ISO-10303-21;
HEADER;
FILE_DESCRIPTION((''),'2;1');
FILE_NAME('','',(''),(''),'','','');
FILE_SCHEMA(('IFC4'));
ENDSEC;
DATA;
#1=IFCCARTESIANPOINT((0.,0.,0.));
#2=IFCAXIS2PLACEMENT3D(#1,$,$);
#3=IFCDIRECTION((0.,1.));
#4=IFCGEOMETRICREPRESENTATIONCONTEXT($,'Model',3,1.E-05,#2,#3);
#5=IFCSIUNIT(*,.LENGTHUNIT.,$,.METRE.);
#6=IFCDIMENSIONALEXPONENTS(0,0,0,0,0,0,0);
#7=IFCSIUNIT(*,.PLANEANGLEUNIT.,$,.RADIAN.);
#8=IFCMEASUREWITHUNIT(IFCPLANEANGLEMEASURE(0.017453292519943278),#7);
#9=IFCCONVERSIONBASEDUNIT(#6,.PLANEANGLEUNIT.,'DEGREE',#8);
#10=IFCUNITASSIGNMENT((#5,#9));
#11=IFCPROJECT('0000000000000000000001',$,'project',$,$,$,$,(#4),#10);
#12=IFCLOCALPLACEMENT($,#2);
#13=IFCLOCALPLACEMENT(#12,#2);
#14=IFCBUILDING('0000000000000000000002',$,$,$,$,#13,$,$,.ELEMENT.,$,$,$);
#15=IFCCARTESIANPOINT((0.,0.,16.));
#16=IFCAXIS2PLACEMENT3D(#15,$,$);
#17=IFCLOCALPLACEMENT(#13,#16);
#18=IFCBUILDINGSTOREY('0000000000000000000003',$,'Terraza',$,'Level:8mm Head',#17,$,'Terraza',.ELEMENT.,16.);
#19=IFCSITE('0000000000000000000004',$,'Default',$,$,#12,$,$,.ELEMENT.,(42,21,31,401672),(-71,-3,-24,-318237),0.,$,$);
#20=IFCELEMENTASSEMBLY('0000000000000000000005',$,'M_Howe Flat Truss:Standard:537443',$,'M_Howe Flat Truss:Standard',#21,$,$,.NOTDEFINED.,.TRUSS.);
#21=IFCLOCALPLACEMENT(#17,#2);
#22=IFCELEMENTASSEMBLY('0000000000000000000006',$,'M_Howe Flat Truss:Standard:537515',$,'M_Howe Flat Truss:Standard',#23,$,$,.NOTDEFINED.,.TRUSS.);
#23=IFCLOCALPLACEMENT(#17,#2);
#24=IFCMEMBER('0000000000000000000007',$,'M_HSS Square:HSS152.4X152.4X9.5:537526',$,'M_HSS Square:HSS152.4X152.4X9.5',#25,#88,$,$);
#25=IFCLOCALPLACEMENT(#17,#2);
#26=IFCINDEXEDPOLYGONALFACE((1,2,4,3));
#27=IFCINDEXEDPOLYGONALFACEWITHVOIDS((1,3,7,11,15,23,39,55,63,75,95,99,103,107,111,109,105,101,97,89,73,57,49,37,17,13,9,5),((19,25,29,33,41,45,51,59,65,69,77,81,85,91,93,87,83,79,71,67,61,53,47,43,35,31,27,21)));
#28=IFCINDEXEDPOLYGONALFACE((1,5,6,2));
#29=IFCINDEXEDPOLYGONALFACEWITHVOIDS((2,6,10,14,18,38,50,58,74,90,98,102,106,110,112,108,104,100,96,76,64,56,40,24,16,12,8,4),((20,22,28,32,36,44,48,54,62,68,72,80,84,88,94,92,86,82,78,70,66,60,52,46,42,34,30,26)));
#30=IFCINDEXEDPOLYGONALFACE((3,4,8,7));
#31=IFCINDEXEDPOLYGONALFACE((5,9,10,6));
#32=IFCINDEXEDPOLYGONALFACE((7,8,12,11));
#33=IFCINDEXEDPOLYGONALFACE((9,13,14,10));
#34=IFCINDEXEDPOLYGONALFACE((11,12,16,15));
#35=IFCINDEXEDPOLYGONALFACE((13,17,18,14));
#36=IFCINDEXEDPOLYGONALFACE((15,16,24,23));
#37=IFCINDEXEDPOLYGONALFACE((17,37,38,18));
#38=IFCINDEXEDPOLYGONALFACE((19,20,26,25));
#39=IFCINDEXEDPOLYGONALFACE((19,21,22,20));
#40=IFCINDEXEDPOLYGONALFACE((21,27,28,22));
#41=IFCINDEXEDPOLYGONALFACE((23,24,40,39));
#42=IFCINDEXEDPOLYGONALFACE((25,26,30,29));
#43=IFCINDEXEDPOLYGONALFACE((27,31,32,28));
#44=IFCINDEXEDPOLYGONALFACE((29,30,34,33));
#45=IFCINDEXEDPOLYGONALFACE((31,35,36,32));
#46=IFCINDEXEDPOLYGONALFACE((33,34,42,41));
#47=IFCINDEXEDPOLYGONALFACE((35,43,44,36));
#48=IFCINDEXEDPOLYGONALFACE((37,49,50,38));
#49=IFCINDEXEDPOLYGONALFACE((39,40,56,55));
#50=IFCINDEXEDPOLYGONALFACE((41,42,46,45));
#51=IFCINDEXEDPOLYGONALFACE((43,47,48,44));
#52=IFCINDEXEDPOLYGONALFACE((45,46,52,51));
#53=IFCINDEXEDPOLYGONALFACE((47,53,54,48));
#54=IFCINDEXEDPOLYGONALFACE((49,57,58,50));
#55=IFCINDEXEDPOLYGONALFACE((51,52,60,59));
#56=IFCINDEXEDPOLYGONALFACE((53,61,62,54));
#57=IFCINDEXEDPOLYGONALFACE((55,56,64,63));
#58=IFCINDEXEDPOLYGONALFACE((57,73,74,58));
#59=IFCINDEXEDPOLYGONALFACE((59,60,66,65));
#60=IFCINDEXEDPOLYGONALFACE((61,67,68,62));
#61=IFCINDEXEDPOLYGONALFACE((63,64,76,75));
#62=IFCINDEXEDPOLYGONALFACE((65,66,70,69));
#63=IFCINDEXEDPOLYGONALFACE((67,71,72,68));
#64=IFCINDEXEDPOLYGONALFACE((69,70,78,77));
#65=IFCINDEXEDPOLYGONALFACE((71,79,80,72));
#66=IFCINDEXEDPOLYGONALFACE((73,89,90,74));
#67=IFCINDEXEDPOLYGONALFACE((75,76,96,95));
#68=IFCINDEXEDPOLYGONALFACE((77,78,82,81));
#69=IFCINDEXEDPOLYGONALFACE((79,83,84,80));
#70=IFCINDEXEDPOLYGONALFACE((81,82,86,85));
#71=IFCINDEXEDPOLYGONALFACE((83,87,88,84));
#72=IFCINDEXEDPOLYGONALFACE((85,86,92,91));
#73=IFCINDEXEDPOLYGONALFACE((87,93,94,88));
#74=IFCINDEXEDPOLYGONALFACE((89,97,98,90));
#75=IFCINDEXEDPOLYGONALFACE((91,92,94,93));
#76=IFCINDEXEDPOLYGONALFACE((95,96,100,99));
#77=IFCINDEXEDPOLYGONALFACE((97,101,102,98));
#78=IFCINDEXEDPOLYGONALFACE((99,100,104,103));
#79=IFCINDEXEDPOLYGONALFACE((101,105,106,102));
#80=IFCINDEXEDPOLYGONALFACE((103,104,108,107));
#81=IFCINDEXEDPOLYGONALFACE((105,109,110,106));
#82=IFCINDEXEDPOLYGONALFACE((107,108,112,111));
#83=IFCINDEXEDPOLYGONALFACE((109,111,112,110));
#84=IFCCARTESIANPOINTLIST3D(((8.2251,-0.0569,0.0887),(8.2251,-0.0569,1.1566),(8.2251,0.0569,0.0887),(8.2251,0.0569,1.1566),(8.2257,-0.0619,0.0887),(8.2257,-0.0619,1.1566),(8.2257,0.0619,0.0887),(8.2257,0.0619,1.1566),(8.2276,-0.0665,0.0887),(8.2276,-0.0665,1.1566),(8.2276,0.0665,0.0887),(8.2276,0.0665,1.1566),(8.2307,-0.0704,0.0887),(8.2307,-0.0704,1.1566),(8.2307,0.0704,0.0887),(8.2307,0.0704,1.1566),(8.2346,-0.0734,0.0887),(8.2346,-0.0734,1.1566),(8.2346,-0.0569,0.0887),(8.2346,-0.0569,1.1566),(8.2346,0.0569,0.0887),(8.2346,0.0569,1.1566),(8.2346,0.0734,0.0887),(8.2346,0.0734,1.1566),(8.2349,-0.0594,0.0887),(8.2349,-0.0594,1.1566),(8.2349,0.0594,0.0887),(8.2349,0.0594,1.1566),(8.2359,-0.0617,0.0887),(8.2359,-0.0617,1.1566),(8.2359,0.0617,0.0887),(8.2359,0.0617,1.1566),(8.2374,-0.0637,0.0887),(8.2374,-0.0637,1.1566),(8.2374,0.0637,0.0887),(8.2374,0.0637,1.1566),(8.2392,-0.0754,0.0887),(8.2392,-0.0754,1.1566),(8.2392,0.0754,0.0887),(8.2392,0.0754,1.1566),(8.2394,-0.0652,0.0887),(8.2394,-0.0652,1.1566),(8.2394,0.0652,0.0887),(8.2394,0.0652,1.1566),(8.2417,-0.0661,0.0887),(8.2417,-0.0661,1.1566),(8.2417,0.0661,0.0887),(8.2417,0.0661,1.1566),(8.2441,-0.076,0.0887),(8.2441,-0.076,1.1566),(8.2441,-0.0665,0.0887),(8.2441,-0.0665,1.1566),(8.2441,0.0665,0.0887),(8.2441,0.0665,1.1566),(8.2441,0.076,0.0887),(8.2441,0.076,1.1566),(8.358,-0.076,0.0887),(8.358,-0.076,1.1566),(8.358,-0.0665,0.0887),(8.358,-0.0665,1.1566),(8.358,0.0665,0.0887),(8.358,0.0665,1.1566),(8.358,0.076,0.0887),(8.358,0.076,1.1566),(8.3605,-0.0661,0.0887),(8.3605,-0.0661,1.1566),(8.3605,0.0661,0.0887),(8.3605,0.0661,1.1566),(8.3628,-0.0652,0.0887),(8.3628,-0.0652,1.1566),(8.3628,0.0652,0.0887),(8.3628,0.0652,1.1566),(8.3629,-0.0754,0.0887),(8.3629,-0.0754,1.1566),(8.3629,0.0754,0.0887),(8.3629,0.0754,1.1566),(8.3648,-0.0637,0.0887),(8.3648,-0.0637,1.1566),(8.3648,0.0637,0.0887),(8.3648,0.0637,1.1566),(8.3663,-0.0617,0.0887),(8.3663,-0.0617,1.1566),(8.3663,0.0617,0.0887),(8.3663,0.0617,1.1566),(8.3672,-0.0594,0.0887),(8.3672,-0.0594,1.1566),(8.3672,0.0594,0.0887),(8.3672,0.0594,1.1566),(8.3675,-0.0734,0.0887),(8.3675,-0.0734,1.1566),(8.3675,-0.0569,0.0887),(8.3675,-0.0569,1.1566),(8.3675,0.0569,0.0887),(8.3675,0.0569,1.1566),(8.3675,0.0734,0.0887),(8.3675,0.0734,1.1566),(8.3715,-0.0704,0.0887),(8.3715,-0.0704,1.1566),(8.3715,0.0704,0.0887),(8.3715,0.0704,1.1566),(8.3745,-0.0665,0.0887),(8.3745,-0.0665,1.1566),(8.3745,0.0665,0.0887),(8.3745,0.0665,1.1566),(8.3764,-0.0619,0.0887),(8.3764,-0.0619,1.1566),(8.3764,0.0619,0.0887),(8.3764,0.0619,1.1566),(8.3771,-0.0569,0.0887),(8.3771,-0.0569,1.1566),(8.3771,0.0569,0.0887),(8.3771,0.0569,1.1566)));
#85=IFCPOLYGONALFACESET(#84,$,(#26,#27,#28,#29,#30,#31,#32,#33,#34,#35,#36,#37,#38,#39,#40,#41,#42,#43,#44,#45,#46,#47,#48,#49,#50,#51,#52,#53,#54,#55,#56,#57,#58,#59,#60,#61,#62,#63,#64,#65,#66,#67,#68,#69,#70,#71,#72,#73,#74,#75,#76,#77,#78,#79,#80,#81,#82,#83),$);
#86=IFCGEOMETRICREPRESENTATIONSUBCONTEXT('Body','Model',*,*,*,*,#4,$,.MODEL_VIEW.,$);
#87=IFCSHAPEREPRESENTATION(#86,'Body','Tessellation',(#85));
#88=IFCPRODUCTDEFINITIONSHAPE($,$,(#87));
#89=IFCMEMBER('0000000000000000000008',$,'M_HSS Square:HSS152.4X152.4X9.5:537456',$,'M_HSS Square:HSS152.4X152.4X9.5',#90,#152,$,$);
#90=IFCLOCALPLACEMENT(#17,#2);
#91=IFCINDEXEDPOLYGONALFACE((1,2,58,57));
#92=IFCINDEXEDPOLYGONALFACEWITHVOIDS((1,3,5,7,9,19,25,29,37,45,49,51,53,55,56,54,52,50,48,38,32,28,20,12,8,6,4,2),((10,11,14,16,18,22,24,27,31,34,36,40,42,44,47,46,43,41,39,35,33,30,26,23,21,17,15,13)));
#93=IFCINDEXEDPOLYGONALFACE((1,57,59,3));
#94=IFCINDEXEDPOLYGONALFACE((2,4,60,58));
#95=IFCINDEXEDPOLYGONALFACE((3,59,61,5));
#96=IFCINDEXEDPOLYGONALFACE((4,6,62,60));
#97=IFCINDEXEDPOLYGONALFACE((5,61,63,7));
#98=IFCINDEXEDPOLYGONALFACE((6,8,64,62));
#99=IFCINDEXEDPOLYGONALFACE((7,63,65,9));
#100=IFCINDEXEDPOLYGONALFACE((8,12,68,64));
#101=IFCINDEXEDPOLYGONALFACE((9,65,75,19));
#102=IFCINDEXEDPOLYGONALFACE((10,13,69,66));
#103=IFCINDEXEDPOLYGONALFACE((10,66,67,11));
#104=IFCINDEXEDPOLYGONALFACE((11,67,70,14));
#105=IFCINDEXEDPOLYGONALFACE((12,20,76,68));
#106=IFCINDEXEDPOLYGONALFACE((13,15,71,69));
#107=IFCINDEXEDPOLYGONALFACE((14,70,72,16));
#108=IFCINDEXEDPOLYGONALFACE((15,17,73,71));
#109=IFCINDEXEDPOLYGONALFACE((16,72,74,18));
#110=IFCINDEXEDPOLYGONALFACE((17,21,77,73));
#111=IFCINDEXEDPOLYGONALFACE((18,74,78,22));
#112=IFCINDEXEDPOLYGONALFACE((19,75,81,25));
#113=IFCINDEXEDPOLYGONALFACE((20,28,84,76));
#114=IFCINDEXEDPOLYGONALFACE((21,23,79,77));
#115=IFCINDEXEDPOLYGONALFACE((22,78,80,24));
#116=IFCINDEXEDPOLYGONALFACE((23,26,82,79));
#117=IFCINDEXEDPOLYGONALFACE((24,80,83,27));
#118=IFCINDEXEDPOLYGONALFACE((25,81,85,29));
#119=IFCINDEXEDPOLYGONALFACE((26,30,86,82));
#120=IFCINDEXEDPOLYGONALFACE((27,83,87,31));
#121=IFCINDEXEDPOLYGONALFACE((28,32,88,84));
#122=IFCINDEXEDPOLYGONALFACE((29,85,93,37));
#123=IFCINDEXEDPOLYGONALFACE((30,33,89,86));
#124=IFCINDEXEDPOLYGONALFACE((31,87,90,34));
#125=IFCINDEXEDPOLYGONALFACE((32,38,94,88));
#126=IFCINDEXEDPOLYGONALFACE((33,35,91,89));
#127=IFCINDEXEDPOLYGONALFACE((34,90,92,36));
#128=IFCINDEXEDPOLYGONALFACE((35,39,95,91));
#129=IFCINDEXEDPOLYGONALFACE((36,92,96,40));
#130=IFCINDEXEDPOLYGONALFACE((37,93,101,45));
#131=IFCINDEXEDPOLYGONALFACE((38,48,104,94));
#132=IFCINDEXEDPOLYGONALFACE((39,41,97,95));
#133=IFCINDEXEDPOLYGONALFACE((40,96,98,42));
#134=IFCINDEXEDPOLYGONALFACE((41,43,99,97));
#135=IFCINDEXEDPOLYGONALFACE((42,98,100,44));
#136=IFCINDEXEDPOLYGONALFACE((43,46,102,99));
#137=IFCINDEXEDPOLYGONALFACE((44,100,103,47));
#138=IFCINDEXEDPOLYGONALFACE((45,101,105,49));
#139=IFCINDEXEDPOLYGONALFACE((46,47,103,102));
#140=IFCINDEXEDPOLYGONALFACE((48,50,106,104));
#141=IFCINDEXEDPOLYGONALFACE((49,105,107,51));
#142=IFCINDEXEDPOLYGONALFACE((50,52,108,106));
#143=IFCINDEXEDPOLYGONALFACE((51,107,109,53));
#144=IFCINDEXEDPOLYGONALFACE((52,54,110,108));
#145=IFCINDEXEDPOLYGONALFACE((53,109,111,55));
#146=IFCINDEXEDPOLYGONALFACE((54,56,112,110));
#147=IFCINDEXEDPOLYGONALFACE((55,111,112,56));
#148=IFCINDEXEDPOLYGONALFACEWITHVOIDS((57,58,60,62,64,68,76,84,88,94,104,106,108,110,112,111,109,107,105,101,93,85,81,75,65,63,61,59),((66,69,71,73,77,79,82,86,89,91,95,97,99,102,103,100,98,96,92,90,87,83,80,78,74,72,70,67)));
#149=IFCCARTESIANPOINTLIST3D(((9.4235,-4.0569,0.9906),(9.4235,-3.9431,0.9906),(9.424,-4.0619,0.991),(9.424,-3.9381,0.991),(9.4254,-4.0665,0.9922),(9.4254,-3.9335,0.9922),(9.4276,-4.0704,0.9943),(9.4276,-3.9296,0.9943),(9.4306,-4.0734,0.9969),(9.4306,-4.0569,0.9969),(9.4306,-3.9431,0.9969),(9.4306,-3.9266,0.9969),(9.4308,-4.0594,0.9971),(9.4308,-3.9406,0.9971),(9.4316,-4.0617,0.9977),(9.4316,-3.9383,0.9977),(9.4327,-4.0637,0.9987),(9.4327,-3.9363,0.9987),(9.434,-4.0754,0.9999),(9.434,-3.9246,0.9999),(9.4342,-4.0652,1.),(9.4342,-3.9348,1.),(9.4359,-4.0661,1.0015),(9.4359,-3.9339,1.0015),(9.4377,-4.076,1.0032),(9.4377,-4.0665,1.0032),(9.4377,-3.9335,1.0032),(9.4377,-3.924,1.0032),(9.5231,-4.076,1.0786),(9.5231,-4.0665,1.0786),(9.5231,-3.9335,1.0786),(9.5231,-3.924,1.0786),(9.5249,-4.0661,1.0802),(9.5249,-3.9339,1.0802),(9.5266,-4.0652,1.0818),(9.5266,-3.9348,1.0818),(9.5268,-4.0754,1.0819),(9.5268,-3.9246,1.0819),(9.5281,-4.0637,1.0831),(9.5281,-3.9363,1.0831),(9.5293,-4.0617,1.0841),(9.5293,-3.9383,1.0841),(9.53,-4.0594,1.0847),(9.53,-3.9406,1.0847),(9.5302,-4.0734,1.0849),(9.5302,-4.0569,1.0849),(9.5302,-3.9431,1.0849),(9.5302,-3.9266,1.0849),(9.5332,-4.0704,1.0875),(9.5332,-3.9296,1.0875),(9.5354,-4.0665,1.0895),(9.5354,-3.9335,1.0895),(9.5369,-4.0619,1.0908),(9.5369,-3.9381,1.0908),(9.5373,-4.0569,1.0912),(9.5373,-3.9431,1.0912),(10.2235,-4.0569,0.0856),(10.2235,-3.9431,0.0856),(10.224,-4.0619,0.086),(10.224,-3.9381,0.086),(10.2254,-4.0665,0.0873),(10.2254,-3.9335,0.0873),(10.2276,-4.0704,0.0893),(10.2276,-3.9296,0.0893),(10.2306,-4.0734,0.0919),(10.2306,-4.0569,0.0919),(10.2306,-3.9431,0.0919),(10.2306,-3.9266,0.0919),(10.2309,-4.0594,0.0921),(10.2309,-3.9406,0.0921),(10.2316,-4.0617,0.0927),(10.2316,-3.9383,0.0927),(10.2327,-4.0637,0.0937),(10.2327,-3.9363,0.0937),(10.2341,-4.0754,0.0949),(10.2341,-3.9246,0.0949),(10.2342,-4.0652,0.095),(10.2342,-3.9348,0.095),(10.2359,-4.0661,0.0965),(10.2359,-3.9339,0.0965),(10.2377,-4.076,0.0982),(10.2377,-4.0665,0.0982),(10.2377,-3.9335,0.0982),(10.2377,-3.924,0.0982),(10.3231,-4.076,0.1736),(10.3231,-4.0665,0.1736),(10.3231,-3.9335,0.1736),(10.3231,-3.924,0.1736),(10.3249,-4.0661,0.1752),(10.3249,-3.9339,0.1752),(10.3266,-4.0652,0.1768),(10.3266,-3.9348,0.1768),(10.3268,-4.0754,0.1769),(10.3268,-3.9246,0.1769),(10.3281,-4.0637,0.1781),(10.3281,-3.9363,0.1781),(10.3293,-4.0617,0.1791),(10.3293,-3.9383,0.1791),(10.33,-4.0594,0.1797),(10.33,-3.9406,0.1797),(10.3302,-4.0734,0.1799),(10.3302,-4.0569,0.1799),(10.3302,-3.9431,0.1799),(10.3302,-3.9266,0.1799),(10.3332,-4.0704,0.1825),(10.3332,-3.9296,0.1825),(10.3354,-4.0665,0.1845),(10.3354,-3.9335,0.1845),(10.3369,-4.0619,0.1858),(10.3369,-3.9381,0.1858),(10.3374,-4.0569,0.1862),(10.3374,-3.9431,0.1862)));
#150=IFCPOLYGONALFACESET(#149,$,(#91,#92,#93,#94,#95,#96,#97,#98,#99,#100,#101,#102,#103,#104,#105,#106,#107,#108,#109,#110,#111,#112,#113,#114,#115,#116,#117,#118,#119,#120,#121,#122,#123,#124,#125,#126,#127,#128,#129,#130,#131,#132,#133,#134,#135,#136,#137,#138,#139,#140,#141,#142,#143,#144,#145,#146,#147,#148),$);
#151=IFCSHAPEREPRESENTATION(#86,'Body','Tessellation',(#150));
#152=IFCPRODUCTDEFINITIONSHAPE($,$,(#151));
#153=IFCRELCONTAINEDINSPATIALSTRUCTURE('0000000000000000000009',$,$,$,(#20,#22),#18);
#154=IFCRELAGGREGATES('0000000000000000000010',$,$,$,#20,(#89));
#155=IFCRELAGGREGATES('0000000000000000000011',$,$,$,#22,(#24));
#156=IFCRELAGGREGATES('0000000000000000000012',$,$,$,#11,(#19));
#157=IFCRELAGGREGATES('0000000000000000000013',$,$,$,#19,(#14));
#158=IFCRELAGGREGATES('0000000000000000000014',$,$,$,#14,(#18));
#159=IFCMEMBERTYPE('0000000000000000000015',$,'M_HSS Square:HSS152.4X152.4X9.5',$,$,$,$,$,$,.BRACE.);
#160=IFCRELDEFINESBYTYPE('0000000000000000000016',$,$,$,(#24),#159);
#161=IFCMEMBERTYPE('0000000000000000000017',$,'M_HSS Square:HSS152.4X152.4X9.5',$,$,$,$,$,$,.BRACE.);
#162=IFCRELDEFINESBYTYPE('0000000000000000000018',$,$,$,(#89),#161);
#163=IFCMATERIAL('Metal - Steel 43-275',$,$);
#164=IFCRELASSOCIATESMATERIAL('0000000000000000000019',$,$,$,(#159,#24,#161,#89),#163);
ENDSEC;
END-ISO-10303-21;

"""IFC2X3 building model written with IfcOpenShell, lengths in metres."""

from ifc_helpers import new_model, entity, si_unit, converted_unit, direction, frame, frame_2d, origin, place, context, subcontext, project, spatial, polyline, circle_curve, parameter, trimmed, segment, composite_curve, outline, extrude, source, transform, mapped, material, type_object, type_shapes, element, aggregate, save


model = new_model("IFC2X3")

# Units and contexts
model_context = context("Model", 3, precision=1e-05, world=origin(), true_north=direction((0.0, 1.0)))
body_context = subcontext(model_context, "Body", "Model", "MODEL_VIEW")
ifc_project = project(units=[si_unit("LENGTHUNIT", "METRE"), converted_unit("PLANEANGLEUNIT", "DEGREE", entity("IfcPlaneAngleMeasure", 0.017453292519943278), si_unit("PLANEANGLEUNIT", "RADIAN"), dimensions=[0, 0, 0, 0, 0, 0, 0])], contexts=[model_context])

# Site, building, storey
site_placement = place(None, origin())
site = spatial("IfcSite", under=ifc_project, at=site_placement, Name="Default", CompositionType="ELEMENT", RefLatitude=(42, 21, 31, 401672), RefLongitude=(-71, -3, -24, -318237), RefElevation=0.0)
building_placement = place(site_placement, origin())
building = spatial("IfcBuilding", under=site, at=building_placement, CompositionType="ELEMENT")
storey_placement = place(building_placement, frame((0.0, 0.0, 16.0)))
storey = spatial("IfcBuildingStorey", under=building, at=storey_placement, Name="Terraza", ObjectType="Level:8mm Head", LongName="Terraza", CompositionType="ELEMENT", Elevation=16.0)

# Element assemblies
ifc_material_1 = material(Name="Metal - Steel 43-275")
assembly_1_placement = place(storey_placement, origin())
assembly_1 = element("IfcElementAssembly", 1, at=assembly_1_placement, inside=storey, Name="M_Howe Flat Truss:Standard:537443", ObjectType="M_Howe Flat Truss:Standard", AssemblyPlace="NOTDEFINED", PredefinedType="TRUSS")
assembly_2_placement = place(storey_placement, origin())
assembly_2 = element("IfcElementAssembly", 2, at=assembly_2_placement, inside=storey, Name="M_Howe Flat Truss:Standard:537515", ObjectType="M_Howe Flat Truss:Standard", AssemblyPlace="NOTDEFINED", PredefinedType="TRUSS")

# Members
member_type_1 = type_object("IfcMemberType", Name="M_HSS Square:HSS152.4X152.4X9.5", PredefinedType="BRACE", material=ifc_material_1)
shared_shape_1 = source(origin(), body_context, "Body", "SweptSolid", [
    extrude(outline(composite_curve([segment(polyline([(-0.0569, -0.076), (0.0569, -0.076)]), True, "CONTINUOUS"), segment(trimmed(circle_curve(frame_2d((0.0569, -0.0569), x_axis=(0.0, 1.0)), 0.0191), [parameter(180.0)], [parameter(270.0)], True, "PARAMETER"), True, "CONTINUOUS"), segment(polyline([(0.076, -0.0569), (0.076, 0.0569)]), True, "CONTINUOUS"), segment(trimmed(circle_curve(frame_2d((0.0569, 0.0569), x_axis=(0.0, 1.0)), 0.0191), [parameter(270.0)], [parameter(0.0)], True, "PARAMETER"), True, "CONTINUOUS"), segment(polyline([(0.0569, 0.076), (-0.0569, 0.076)]), True, "CONTINUOUS"), segment(trimmed(circle_curve(frame_2d((-0.0569, 0.0569), x_axis=(0.0, 1.0)), 0.0191), [parameter(0.0)], [parameter(90.0)], True, "PARAMETER"), True, "CONTINUOUS"), segment(polyline([(-0.076, 0.0569), (-0.076, -0.0569)]), True, "CONTINUOUS"), segment(trimmed(circle_curve(frame_2d((-0.0569, -0.0569), x_axis=(0.0, 1.0)), 0.0191), [parameter(90.0)], [parameter(180.0)], True, "PARAMETER"), True, "CONTINUOUS")], self_intersect=False), holes=[composite_curve([segment(trimmed(circle_curve(frame_2d((-0.0569, 0.0569), x_axis=(0.0, 1.0)), 0.0095), [parameter(360.0)], [parameter(90.0)], True, "PARAMETER"), False, "CONTINUOUS"), segment(polyline([(-0.0569, 0.0665), (0.0569, 0.0665)]), True, "CONTINUOUS"), segment(trimmed(circle_curve(frame_2d((0.0569, 0.0569), x_axis=(0.0, 1.0)), 0.0095), [parameter(270.0)], [parameter(360.0)], True, "PARAMETER"), False, "CONTINUOUS"), segment(polyline([(0.0665, 0.0569), (0.0665, -0.0569)]), True, "CONTINUOUS"), segment(trimmed(circle_curve(frame_2d((0.0569, -0.0569), x_axis=(0.0, 1.0)), 0.0095), [parameter(180.0)], [parameter(270.0)], True, "PARAMETER"), False, "CONTINUOUS"), segment(polyline([(0.0569, -0.0665), (-0.0569, -0.0665)]), True, "CONTINUOUS"), segment(trimmed(circle_curve(frame_2d((-0.0569, -0.0569), x_axis=(0.0, 1.0)), 0.0095), [parameter(90.0)], [parameter(180.0)], True, "PARAMETER"), False, "CONTINUOUS"), segment(polyline([(-0.0665, -0.0569), (-0.0665, 0.0569)]), True, "CONTINUOUS")], self_intersect=False)]), frame((-0.5363, 0.0, 0.0), z_axis=(1.0, 0.0, 0.0), x_axis=(0.0, 0.0, -1.0)), (0.0, 0.0, 1.0), 1.0679),
])
type_shapes(member_type_1, [shared_shape_1])
member_1_placement = place(assembly_2_placement, frame((8.3011, 0.0, 0.625), z_axis=(1.0, 0.0, 0.0), x_axis=(0.0, 0.0, 1.0)))
member_1 = element("IfcMember", 3, at=member_1_placement, type_object=member_type_1, material=ifc_material_1, Name="M_HSS Square:HSS152.4X152.4X9.5:537526", ObjectType="M_HSS Square:HSS152.4X152.4X9.5", context=body_context, shape_type="MappedRepresentation", body=[
    mapped(shared_shape_1, transform((0.0, 0.0, 0.0), scale=1.0)),
])
member_type_2 = type_object("IfcMemberType", Name="M_HSS Square:HSS152.4X152.4X9.5", PredefinedType="BRACE", material=ifc_material_1)
shared_shape_2 = source(origin(), body_context, "Body", "SweptSolid", [
    extrude(outline(composite_curve([segment(polyline([(-0.0569, -0.076), (0.0569, -0.076)]), True, "CONTINUOUS"), segment(trimmed(circle_curve(frame_2d((0.0569, -0.0569), x_axis=(0.0, 1.0)), 0.0191), [parameter(180.0)], [parameter(270.0)], True, "PARAMETER"), True, "CONTINUOUS"), segment(polyline([(0.076, -0.0569), (0.076, 0.0569)]), True, "CONTINUOUS"), segment(trimmed(circle_curve(frame_2d((0.0569, 0.0569), x_axis=(0.0, 1.0)), 0.0191), [parameter(270.0)], [parameter(0.0)], True, "PARAMETER"), True, "CONTINUOUS"), segment(polyline([(0.0569, 0.076), (-0.0569, 0.076)]), True, "CONTINUOUS"), segment(trimmed(circle_curve(frame_2d((-0.0569, 0.0569), x_axis=(0.0, 1.0)), 0.0191), [parameter(0.0)], [parameter(90.0)], True, "PARAMETER"), True, "CONTINUOUS"), segment(polyline([(-0.076, 0.0569), (-0.076, -0.0569)]), True, "CONTINUOUS"), segment(trimmed(circle_curve(frame_2d((-0.0569, -0.0569), x_axis=(0.0, 1.0)), 0.0191), [parameter(90.0)], [parameter(180.0)], True, "PARAMETER"), True, "CONTINUOUS")], self_intersect=False), holes=[composite_curve([segment(trimmed(circle_curve(frame_2d((-0.0569, 0.0569), x_axis=(0.0, 1.0)), 0.0095), [parameter(360.0)], [parameter(90.0)], True, "PARAMETER"), False, "CONTINUOUS"), segment(polyline([(-0.0569, 0.0665), (0.0569, 0.0665)]), True, "CONTINUOUS"), segment(trimmed(circle_curve(frame_2d((0.0569, 0.0569), x_axis=(0.0, 1.0)), 0.0095), [parameter(270.0)], [parameter(360.0)], True, "PARAMETER"), False, "CONTINUOUS"), segment(polyline([(0.0665, 0.0569), (0.0665, -0.0569)]), True, "CONTINUOUS"), segment(trimmed(circle_curve(frame_2d((0.0569, -0.0569), x_axis=(0.0, 1.0)), 0.0095), [parameter(180.0)], [parameter(270.0)], True, "PARAMETER"), False, "CONTINUOUS"), segment(polyline([(0.0569, -0.0665), (-0.0569, -0.0665)]), True, "CONTINUOUS"), segment(trimmed(circle_curve(frame_2d((-0.0569, -0.0569), x_axis=(0.0, 1.0)), 0.0095), [parameter(90.0)], [parameter(180.0)], True, "PARAMETER"), False, "CONTINUOUS"), segment(polyline([(-0.0665, -0.0569), (-0.0665, 0.0569)]), True, "CONTINUOUS")], self_intersect=False)]), frame((-0.5968, 0.0, 0.0), z_axis=(1.0, 0.0, 0.0), x_axis=(0.0, 0.0, -1.0)), (0.0, 0.0, 1.0), 1.2079),
])
type_shapes(member_type_2, [shared_shape_2])
member_2_placement = place(assembly_1_placement, frame((9.8757, -4.0, 0.5937), z_axis=(-0.749231, 0.0, -0.662309), x_axis=(0.662309, 0.0, -0.749231)))
member_2 = element("IfcMember", 4, at=member_2_placement, type_object=member_type_2, material=ifc_material_1, Name="M_HSS Square:HSS152.4X152.4X9.5:537456", ObjectType="M_HSS Square:HSS152.4X152.4X9.5", context=body_context, shape_type="MappedRepresentation", body=[
    mapped(shared_shape_2, transform((0.0, 0.0, 0.0), scale=1.0)),
])
aggregate(assembly_1, [member_2])
aggregate(assembly_2, [member_1])

save(model, "model.ifc")
